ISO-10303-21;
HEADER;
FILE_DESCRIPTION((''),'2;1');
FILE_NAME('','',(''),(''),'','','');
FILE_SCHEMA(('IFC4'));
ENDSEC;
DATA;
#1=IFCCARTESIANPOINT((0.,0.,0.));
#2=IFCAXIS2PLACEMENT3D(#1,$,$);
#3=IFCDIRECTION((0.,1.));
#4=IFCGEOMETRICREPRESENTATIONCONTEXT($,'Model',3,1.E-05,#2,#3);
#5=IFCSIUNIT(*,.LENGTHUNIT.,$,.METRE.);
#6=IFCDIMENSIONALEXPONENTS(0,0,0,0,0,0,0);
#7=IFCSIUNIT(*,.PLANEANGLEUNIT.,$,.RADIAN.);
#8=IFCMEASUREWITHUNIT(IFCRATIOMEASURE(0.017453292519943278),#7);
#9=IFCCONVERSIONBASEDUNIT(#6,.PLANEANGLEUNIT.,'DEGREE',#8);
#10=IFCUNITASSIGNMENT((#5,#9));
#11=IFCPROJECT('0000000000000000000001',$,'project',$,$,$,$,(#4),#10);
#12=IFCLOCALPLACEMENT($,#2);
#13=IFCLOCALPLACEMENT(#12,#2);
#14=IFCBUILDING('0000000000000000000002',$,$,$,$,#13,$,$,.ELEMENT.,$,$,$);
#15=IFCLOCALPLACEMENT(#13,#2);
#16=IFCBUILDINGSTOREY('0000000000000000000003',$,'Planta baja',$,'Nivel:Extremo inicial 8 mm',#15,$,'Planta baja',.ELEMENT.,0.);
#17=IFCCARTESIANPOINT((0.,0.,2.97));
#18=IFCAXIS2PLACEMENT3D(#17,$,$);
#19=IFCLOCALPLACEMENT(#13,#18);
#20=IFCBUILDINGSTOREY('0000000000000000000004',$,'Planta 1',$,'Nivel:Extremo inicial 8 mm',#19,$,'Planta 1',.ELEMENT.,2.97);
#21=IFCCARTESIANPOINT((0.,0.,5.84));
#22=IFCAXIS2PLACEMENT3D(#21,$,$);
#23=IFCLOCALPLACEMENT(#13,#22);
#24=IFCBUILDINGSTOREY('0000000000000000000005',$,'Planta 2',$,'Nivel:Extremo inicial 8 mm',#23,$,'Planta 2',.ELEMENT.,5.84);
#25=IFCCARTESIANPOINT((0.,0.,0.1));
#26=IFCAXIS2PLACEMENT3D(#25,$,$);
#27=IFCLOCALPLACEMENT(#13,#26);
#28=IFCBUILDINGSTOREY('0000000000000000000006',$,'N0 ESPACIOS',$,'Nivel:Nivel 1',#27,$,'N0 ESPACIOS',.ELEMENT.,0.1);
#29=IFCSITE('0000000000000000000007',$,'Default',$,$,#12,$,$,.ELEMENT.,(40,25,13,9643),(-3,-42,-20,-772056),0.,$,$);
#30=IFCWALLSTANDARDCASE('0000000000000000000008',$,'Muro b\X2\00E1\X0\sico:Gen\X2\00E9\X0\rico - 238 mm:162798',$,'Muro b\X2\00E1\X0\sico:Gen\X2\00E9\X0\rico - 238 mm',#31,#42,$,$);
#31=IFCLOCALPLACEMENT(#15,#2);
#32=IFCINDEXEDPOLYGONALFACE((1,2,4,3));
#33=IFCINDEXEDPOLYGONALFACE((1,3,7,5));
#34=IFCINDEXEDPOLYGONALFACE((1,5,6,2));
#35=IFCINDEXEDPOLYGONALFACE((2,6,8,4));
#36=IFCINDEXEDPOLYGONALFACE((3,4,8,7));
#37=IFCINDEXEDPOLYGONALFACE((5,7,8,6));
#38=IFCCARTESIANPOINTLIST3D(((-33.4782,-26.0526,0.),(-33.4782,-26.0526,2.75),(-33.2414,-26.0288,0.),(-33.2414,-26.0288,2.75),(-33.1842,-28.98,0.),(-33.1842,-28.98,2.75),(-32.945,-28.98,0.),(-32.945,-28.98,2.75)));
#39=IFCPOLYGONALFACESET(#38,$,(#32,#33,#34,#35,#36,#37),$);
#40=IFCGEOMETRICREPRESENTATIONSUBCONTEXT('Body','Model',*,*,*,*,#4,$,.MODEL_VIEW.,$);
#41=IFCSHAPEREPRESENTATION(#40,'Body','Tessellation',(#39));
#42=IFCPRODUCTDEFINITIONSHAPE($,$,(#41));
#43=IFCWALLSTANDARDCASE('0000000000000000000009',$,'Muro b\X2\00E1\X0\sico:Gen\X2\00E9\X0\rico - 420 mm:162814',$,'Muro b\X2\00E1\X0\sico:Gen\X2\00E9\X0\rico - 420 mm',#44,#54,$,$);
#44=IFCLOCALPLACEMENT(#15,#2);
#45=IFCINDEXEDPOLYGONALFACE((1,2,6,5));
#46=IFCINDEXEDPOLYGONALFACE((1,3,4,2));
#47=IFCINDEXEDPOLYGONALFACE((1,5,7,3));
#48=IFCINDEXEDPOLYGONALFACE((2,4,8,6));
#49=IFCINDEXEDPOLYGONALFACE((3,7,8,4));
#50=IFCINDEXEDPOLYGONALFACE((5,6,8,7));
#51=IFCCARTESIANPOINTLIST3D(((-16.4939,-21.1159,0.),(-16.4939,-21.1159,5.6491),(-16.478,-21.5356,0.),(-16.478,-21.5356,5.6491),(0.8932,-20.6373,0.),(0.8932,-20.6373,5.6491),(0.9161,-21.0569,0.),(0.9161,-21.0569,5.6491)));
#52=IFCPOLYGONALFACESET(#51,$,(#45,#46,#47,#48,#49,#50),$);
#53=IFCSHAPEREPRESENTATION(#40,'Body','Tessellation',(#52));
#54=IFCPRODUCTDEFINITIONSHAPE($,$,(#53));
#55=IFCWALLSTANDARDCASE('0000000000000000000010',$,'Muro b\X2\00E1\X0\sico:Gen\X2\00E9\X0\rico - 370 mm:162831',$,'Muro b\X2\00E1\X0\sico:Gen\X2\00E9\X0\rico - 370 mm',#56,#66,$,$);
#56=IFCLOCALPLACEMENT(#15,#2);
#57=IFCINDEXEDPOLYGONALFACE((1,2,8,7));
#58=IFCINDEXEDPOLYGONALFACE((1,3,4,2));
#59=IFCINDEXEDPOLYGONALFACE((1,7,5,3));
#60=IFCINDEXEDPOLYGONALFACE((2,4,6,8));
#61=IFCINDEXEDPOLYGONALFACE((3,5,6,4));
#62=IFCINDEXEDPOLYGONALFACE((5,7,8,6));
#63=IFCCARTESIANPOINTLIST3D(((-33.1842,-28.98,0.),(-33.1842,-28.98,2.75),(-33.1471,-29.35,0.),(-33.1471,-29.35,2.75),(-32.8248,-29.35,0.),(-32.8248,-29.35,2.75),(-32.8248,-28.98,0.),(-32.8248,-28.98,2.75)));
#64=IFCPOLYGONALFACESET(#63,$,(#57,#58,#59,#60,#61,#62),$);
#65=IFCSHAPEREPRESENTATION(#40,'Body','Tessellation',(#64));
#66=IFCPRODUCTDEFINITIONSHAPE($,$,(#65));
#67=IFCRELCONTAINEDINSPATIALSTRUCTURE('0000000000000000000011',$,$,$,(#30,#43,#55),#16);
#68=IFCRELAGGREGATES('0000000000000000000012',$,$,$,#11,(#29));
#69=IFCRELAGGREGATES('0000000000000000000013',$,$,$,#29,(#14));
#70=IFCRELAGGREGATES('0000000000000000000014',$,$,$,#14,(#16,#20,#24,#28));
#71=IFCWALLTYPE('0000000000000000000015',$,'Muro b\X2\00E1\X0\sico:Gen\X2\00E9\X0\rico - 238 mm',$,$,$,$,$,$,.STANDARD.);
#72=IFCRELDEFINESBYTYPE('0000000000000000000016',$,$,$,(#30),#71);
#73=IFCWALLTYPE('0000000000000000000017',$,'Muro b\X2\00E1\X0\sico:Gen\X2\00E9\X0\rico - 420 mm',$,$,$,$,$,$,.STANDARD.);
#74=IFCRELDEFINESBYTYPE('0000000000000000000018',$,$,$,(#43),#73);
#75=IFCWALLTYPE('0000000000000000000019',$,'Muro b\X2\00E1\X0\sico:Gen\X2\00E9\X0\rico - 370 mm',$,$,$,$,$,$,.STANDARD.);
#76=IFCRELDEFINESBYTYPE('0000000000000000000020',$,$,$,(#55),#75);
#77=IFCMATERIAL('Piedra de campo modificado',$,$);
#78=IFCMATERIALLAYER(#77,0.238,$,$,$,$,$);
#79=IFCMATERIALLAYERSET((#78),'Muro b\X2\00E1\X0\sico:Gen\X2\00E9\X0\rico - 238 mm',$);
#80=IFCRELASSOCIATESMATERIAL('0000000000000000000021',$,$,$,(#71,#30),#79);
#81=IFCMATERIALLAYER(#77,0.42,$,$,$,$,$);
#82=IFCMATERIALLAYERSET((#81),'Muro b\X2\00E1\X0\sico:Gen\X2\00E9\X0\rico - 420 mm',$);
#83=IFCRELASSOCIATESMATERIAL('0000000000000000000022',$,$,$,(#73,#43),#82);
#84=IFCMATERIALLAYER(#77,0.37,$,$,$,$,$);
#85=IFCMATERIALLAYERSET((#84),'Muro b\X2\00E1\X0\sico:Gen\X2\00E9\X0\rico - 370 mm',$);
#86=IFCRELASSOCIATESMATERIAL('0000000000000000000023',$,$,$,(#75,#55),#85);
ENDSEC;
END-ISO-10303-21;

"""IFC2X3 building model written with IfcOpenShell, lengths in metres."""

from ifc_helpers import new_model, entity, si_unit, converted_unit, direction, frame, origin, place, context, subcontext, project, spatial, polyline, outline, extrude, clip, bounded_halfspace, material, layer, layer_set, layer_usage, type_object, element, save


model = new_model("IFC2X3")

# Units and contexts
model_context = context("Model", 3, precision=1e-05, world=origin(), true_north=direction((0.0, 1.0)))
body_context = subcontext(model_context, "Body", "Model", "MODEL_VIEW")
ifc_project = project(units=[si_unit("LENGTHUNIT", "METRE"), converted_unit("PLANEANGLEUNIT", "DEGREE", entity("IfcRatioMeasure", 0.017453292519943278), si_unit("PLANEANGLEUNIT", "RADIAN"), dimensions=[0, 0, 0, 0, 0, 0, 0])], contexts=[model_context])

# Site, building, storey
site_placement = place(None, origin())
site = spatial("IfcSite", under=ifc_project, at=site_placement, Name="Default", CompositionType="ELEMENT", RefLatitude=(40, 25, 13, 9643), RefLongitude=(-3, -42, -20, -772056), RefElevation=0.0)
building_placement = place(site_placement, origin())
building = spatial("IfcBuilding", under=site, at=building_placement, CompositionType="ELEMENT")
storey_1_placement = place(building_placement, origin())
storey_1 = spatial("IfcBuildingStorey", under=building, at=storey_1_placement, Name="Planta baja", ObjectType="Nivel:Extremo inicial 8 mm", LongName="Planta baja", CompositionType="ELEMENT", Elevation=0.0)

# Shared definitions
ifc_material_1 = material(Name="Piedra de campo modificado")

# Shared definitions
storey_2_placement = place(building_placement, frame((0.0, 0.0, 2.97)))
storey_2 = spatial("IfcBuildingStorey", under=building, at=storey_2_placement, Name="Planta 1", ObjectType="Nivel:Extremo inicial 8 mm", LongName="Planta 1", CompositionType="ELEMENT", Elevation=2.97)

# Shared definitions
storey_3_placement = place(building_placement, frame((0.0, 0.0, 5.84)))
storey_3 = spatial("IfcBuildingStorey", under=building, at=storey_3_placement, Name="Planta 2", ObjectType="Nivel:Extremo inicial 8 mm", LongName="Planta 2", CompositionType="ELEMENT", Elevation=5.84)

# Wall
ifc_layer_1 = layer(ifc_material_1, 0.238)
ifc_layer_set_1 = layer_set([ifc_layer_1], Name="Muro básico:Genérico - 238 mm")
ifc_layer_usage_1 = layer_usage(ifc_layer_set_1, "AXIS2", "NEGATIVE", 0.119)
wall_type_1 = type_object("IfcWallType", Name="Muro básico:Genérico - 238 mm", PredefinedType="STANDARD", material=ifc_layer_set_1)
wall_1_placement = place(storey_1_placement, frame((-33.3598, -26.0407, 0.0), z_axis=(0.0, 0.0, 1.0), x_axis=(0.09992, -0.994996, 0.0)))
element("IfcWallStandardCase", 1, at=wall_1_placement, inside=storey_1, type_object=wall_type_1, material=ifc_layer_usage_1, Name="Muro básico:Genérico - 238 mm:162798", ObjectType="Muro básico:Genérico - 238 mm", context=body_context, shape_type="Clipping", body=[
    clip(extrude(outline(polyline([(2.9421, -0.119), (2.966, 0.119), (0.0, 0.119), (0.0, -0.119), (2.9421, -0.119)])), origin(), (0.0, 0.0, 1.0), 2.75), bounded_halfspace(frame((0.0216, -0.119, 2.75), z_axis=(0.0, 0.0, -1.0), x_axis=(-1.0, 0.0, 0.0)), True, frame((0.0216, -0.119, 2.75)), polyline([(0.0, 0.0), (2.9205, 0.0), (2.9444, 0.238), (0.0283, 0.238), (0.0, 0.0)]))),
])

# Shared definitions
storey_4_placement = place(building_placement, frame((0.0, 0.0, 0.1)))
storey_4 = spatial("IfcBuildingStorey", under=building, at=storey_4_placement, Name="N0 ESPACIOS", ObjectType="Nivel:Nivel 1", LongName="N0 ESPACIOS", CompositionType="ELEMENT", Elevation=0.1)

# Walls
ifc_layer_2 = layer(ifc_material_1, 0.42)
ifc_layer_set_2 = layer_set([ifc_layer_2], Name="Muro básico:Genérico - 420 mm")
ifc_layer_usage_2 = layer_usage(ifc_layer_set_2, "AXIS2", "NEGATIVE", 0.21)
wall_type_2 = type_object("IfcWallType", Name="Muro básico:Genérico - 420 mm", PredefinedType="STANDARD", material=ifc_layer_set_2)
wall_2_placement = place(storey_1_placement, frame((-16.4881, -21.3258, 0.0), z_axis=(0.0, 0.0, 1.0), x_axis=(0.999621, 0.027514, 0.0)))
element("IfcWallStandardCase", 2, at=wall_2_placement, inside=storey_1, type_object=wall_type_2, material=ifc_layer_usage_2, Name="Muro básico:Genérico - 420 mm:162814", ObjectType="Muro básico:Genérico - 420 mm", context=body_context, shape_type="SweptSolid", body=[
    extrude(outline(polyline([(17.405, -0.21), (17.3937, 0.21), (0.0, 0.21), (0.0043, -0.21), (17.405, -0.21)])), origin(), (0.0, 0.0, 1.0), 5.6491),
])
ifc_layer_3 = layer(ifc_material_1, 0.37)
ifc_layer_set_3 = layer_set([ifc_layer_3], Name="Muro básico:Genérico - 370 mm")
ifc_layer_usage_3 = layer_usage(ifc_layer_set_3, "AXIS2", "NEGATIVE", 0.185)
wall_type_3 = type_object("IfcWallType", Name="Muro básico:Genérico - 370 mm", PredefinedType="STANDARD", material=ifc_layer_set_3)
wall_3_placement = place(storey_1_placement, frame((-33.1842, -29.165, 0.0)))
element("IfcWallStandardCase", 3, at=wall_3_placement, inside=storey_1, type_object=wall_type_3, material=ifc_layer_usage_3, Name="Muro básico:Genérico - 370 mm:162831", ObjectType="Muro básico:Genérico - 370 mm", context=body_context, shape_type="Clipping", body=[
    clip(extrude(outline(polyline([(0.3595, -0.185), (0.3595, 0.135), (0.3595, 0.185), (0.2392, 0.185), (0.0, 0.185), (0.0372, -0.185), (0.3595, -0.185)])), origin(), (0.0, 0.0, 1.0), 2.75), bounded_halfspace(frame((0.0372, -0.185, 2.75), z_axis=(0.0, 0.0, -1.0), x_axis=(-0.09992, 0.994996, 0.0)), True, frame((0.0372, -0.185, 2.75)), polyline([(0.0, 0.0), (0.3223, 0.0), (0.3223, 0.32), (0.3223, 0.37), (0.202, 0.37), (-0.0372, 0.37), (0.0, 0.0)]))),
])

save(model, "model.ifc")
